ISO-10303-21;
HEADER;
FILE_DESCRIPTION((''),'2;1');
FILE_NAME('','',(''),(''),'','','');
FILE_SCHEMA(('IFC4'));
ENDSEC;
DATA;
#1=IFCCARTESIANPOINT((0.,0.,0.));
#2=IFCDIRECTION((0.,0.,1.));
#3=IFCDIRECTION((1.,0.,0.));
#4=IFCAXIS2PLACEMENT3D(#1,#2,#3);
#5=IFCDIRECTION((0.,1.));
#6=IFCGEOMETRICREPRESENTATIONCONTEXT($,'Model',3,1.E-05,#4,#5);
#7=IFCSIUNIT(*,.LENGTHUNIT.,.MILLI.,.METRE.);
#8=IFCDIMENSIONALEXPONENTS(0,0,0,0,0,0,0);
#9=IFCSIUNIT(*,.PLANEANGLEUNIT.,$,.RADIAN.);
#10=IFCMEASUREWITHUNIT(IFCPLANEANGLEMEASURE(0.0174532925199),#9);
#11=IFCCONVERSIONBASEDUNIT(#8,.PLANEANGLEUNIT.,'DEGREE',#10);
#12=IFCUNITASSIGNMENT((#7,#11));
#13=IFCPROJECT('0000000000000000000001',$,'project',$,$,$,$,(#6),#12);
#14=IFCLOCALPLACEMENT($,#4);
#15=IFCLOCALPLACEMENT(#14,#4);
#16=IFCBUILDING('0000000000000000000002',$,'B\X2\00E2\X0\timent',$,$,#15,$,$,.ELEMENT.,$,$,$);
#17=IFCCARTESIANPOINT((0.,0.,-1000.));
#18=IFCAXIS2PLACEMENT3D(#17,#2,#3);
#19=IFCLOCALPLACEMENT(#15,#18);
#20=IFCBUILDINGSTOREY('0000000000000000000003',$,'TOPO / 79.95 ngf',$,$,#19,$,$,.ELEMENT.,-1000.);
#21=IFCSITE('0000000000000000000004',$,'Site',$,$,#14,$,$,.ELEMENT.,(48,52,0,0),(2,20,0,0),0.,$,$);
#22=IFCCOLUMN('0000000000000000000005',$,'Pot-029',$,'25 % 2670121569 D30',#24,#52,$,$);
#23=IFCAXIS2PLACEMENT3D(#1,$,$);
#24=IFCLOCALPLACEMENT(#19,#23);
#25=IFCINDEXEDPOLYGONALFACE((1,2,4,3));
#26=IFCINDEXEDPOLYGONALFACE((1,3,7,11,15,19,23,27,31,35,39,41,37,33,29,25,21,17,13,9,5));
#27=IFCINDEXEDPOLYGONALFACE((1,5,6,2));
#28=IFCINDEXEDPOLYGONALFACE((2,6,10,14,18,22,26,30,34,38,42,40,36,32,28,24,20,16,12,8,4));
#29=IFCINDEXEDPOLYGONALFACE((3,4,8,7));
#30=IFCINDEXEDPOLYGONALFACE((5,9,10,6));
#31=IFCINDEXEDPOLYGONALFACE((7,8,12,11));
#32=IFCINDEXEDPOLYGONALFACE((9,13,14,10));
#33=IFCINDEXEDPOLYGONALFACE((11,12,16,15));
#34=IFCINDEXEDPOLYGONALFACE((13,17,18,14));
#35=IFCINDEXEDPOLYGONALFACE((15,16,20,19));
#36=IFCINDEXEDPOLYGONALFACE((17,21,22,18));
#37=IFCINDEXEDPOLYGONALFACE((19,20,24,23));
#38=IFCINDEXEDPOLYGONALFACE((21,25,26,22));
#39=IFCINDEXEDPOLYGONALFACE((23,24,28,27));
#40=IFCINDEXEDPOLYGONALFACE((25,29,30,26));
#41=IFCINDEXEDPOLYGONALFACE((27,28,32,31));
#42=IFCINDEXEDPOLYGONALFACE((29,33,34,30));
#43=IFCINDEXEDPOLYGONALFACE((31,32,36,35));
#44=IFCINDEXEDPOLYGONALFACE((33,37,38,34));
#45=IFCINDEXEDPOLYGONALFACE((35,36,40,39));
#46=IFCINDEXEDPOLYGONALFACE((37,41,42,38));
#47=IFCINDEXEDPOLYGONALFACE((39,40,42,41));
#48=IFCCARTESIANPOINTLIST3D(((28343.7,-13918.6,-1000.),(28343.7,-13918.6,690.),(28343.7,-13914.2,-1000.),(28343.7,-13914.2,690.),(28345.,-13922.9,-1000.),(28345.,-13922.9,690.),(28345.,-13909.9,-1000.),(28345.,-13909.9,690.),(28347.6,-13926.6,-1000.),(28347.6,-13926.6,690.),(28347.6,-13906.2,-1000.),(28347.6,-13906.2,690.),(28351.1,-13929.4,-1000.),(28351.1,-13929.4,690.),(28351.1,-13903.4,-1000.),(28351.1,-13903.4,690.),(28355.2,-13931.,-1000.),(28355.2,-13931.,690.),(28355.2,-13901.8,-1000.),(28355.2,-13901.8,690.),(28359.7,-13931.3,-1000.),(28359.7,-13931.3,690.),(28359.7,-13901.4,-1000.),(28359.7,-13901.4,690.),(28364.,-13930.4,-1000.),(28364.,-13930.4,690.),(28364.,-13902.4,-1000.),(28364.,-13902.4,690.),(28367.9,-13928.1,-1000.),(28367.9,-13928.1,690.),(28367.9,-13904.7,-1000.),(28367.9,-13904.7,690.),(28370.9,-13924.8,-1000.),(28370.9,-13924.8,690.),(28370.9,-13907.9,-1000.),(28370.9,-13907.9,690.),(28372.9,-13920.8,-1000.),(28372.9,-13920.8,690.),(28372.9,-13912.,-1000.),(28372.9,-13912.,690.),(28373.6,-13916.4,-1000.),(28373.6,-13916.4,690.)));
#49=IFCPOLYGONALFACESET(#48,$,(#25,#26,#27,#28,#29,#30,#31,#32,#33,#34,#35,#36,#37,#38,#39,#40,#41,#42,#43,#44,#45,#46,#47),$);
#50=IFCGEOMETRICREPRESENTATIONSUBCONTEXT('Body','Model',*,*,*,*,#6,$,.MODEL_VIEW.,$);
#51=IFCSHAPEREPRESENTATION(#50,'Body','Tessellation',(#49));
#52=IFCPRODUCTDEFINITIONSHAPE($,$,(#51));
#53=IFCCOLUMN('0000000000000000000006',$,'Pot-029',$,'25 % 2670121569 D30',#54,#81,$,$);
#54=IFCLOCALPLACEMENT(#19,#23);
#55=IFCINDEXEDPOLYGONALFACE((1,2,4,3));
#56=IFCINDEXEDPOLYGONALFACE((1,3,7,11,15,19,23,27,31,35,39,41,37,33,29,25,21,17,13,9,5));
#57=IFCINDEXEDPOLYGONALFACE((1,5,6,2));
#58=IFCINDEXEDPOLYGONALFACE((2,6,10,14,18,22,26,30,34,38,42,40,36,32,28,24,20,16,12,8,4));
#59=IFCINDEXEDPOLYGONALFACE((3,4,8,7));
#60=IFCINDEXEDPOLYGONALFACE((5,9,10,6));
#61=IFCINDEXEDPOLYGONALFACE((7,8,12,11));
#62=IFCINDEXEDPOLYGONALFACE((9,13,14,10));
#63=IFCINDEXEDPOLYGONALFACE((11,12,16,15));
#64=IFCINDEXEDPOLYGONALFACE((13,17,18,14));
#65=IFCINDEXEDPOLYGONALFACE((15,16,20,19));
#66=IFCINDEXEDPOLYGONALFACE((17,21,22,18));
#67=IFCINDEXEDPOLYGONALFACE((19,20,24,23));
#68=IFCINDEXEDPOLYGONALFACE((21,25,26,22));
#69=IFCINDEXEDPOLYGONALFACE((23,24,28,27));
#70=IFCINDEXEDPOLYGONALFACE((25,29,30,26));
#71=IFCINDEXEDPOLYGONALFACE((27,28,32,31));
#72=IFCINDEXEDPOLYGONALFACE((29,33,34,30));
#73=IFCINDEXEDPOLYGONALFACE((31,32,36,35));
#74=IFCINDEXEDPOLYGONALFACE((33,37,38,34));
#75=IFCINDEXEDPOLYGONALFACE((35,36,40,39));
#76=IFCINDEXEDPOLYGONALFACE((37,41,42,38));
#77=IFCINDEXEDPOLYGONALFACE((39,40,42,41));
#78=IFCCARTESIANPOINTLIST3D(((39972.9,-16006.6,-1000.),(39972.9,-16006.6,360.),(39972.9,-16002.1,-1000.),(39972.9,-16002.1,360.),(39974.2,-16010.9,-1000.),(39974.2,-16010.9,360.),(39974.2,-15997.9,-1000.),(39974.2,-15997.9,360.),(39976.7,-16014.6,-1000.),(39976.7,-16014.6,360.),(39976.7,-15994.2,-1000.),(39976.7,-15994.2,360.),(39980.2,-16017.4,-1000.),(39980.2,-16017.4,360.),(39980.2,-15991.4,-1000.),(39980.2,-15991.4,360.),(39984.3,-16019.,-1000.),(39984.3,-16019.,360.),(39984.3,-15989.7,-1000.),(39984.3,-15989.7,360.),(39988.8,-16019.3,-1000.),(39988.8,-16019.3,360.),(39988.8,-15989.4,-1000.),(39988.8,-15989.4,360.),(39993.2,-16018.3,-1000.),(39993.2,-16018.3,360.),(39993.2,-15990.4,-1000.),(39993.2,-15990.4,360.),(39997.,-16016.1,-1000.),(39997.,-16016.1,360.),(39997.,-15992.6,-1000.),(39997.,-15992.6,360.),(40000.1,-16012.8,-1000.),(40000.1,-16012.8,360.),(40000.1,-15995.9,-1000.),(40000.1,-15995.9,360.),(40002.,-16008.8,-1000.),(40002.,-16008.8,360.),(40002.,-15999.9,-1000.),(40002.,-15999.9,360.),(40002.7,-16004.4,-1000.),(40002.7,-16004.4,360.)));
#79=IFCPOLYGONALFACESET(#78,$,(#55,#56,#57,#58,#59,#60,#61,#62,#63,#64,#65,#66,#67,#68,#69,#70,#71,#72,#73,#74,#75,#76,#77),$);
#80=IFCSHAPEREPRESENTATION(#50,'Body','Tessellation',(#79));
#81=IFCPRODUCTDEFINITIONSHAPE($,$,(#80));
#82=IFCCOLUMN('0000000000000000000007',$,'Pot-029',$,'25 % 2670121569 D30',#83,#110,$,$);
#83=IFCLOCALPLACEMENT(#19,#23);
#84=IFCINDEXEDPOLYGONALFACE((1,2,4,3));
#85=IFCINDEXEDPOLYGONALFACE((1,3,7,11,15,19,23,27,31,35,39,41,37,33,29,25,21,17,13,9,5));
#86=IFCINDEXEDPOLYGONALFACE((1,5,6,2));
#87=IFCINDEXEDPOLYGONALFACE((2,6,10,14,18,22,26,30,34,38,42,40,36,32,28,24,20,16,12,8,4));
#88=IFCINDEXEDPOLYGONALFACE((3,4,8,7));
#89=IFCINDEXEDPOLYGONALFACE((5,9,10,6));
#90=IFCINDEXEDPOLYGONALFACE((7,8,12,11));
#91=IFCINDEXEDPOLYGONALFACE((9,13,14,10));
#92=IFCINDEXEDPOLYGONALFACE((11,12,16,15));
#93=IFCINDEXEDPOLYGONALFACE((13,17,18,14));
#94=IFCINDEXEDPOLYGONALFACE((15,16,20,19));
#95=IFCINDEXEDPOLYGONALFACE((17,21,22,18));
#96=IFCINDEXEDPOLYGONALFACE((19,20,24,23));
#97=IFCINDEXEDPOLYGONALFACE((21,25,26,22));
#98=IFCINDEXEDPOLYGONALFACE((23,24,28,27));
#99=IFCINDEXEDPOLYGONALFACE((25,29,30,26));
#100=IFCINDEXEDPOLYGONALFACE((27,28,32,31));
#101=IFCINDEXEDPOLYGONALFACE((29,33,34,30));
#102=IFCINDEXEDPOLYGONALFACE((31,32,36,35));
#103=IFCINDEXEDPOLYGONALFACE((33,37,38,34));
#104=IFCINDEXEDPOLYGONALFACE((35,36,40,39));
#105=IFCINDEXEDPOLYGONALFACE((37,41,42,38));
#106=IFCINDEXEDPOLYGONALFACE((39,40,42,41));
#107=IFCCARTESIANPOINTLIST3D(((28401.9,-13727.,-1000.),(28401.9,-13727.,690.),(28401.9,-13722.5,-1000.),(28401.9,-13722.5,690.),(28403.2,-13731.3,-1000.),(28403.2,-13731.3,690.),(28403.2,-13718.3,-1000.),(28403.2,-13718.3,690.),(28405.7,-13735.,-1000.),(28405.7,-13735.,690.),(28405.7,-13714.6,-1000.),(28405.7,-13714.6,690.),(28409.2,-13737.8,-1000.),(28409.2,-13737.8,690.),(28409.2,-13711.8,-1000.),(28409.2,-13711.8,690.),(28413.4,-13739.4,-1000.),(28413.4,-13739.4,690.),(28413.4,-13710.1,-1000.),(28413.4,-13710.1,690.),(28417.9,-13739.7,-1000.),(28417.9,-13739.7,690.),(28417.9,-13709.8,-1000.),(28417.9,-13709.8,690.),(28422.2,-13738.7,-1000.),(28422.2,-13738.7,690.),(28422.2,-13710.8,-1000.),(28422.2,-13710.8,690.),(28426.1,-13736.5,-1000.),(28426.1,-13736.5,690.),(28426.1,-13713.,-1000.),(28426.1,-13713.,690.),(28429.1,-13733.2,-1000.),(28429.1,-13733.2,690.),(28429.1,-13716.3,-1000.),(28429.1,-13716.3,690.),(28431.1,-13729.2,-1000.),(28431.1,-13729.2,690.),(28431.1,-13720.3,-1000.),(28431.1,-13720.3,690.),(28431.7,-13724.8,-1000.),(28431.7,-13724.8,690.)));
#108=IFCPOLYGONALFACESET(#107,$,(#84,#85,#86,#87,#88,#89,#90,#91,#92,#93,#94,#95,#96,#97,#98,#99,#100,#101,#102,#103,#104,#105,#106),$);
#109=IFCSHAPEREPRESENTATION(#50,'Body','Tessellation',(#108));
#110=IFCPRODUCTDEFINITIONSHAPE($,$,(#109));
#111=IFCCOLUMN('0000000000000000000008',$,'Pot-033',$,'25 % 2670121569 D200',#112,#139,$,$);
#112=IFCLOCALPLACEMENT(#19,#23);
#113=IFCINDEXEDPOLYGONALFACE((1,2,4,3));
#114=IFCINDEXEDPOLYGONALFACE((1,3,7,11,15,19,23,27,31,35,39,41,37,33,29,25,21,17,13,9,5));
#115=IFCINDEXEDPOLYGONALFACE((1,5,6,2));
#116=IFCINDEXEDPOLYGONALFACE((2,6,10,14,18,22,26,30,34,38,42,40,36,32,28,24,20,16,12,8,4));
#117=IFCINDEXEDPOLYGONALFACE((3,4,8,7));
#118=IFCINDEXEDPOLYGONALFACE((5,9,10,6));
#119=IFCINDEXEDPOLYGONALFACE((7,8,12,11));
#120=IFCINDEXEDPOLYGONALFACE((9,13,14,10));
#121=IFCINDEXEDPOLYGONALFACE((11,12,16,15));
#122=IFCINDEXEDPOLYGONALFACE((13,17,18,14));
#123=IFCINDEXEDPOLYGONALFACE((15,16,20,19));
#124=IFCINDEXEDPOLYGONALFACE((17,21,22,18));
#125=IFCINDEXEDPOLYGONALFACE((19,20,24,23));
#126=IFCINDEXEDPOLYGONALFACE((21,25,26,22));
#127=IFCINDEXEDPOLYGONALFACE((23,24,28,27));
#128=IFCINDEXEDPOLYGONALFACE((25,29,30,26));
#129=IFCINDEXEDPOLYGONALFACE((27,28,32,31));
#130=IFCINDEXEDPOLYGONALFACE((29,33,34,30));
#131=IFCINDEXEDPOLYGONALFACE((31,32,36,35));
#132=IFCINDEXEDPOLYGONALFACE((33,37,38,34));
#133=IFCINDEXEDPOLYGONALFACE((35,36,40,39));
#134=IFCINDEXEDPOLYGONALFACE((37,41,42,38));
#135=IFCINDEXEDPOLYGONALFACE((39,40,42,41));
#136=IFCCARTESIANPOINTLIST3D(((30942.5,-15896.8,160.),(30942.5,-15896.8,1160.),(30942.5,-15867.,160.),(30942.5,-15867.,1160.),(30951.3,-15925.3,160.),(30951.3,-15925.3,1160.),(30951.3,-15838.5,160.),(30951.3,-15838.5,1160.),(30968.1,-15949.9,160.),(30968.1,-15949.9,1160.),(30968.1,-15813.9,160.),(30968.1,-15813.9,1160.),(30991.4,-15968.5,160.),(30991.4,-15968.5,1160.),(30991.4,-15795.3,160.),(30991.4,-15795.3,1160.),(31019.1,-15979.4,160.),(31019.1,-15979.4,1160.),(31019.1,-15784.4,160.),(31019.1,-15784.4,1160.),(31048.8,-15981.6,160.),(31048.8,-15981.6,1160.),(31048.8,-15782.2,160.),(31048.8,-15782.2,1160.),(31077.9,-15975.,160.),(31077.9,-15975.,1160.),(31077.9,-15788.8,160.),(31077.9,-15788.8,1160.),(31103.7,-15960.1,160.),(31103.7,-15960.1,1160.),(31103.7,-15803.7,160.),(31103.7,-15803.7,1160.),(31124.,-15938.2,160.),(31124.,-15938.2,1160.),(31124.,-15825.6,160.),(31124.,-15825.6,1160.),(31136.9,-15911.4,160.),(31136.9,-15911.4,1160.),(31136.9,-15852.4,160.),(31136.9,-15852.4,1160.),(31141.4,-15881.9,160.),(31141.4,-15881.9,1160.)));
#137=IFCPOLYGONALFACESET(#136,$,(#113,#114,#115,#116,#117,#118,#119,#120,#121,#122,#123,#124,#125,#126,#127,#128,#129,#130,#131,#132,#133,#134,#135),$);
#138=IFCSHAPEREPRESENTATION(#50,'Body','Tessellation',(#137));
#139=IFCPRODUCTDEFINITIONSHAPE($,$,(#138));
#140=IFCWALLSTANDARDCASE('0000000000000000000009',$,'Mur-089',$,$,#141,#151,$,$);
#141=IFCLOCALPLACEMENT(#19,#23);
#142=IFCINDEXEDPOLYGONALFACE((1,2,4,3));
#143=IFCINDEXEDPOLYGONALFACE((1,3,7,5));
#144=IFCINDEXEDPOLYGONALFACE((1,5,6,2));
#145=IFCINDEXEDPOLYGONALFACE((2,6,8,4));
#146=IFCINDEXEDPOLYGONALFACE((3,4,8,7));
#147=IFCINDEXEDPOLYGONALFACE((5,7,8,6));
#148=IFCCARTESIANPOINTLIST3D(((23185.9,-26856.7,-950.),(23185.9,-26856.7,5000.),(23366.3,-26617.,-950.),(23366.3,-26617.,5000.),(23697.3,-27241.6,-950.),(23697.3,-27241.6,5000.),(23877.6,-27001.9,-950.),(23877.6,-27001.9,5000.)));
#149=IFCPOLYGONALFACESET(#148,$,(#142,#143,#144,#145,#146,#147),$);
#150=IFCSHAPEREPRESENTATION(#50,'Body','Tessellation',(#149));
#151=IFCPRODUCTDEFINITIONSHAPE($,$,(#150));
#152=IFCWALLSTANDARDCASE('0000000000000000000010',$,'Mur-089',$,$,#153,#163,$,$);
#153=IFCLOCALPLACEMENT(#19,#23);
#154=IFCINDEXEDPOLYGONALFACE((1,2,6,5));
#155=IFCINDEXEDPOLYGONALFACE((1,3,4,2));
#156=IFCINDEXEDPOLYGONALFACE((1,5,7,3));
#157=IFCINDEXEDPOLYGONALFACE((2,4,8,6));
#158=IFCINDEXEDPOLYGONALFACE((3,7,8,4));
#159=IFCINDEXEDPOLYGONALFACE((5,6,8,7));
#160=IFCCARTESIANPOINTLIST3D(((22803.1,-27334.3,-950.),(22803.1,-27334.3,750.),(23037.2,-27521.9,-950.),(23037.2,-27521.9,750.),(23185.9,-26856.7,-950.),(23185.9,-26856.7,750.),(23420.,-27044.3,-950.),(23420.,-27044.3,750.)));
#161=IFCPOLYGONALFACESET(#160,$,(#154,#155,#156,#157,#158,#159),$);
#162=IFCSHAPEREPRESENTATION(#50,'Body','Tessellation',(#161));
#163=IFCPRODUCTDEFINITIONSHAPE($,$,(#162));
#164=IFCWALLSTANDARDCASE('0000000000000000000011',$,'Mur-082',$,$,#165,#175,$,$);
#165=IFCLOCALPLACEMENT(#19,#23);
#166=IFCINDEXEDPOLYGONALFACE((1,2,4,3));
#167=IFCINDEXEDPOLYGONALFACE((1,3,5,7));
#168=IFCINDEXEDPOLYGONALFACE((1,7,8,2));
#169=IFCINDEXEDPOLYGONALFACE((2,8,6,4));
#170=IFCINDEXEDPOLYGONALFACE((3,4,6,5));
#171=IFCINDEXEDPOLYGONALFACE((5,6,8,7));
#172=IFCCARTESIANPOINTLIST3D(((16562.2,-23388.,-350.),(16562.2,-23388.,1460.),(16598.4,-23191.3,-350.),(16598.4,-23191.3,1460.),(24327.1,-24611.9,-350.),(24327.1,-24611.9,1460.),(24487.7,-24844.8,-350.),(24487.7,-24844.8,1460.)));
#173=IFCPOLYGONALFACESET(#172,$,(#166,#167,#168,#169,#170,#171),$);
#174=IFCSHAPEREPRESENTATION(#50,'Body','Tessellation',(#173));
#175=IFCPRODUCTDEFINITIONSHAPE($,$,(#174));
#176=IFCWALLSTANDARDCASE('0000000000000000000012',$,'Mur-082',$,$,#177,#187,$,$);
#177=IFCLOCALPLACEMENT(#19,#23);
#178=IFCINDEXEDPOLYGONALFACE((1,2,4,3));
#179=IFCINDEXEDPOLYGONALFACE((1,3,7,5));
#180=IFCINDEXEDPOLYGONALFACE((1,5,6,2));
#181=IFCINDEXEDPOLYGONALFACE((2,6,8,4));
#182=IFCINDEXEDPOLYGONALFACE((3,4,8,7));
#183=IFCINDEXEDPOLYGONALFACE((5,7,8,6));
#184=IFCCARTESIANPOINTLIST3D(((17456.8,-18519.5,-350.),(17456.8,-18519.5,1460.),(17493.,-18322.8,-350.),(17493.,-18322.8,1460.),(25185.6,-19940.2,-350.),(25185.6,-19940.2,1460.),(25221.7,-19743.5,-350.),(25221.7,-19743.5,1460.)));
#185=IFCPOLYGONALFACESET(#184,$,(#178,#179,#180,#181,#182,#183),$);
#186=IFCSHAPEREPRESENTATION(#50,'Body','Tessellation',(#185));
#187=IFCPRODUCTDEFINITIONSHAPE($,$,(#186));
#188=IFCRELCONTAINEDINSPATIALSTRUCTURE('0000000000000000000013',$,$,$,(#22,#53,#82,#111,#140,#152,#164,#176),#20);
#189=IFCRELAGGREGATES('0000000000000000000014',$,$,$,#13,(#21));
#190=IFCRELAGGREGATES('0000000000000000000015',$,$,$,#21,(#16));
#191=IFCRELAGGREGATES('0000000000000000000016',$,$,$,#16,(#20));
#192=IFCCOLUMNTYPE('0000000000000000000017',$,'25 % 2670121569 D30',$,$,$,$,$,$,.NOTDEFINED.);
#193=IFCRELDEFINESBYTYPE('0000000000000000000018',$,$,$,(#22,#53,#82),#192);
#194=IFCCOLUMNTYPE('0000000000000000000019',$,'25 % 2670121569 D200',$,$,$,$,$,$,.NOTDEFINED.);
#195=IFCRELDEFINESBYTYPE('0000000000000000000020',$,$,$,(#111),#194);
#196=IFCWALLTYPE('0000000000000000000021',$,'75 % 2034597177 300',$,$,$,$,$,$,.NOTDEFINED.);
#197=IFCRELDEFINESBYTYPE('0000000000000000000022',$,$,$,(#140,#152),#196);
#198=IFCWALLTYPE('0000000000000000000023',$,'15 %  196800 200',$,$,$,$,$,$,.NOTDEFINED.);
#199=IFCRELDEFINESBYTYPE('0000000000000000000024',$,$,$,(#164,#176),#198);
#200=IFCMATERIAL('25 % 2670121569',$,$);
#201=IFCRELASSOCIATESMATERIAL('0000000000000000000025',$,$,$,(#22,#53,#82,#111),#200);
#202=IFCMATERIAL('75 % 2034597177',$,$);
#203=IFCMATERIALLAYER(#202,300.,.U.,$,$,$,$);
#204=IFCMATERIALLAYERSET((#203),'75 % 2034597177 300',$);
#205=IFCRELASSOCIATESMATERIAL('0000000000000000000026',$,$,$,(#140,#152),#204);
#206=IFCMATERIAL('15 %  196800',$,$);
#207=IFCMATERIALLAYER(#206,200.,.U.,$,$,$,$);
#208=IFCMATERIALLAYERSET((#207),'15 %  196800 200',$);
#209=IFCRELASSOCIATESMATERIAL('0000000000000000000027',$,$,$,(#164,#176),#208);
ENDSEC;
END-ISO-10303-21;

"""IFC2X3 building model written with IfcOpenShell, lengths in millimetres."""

from ifc_helpers import new_model, entity, si_unit, converted_unit, direction, frame, origin_with_axes, origin_2d_with_axis, place, context, subcontext, project, spatial, polyline, circle, outline, extrude, material, layer, layer_set, layer_usage, type_object, element, save


model = new_model("IFC2X3")

# Units and contexts
model_context = context("Model", 3, precision=1e-05, world=origin_with_axes(), true_north=direction((0.0, 1.0)))
body_context = subcontext(model_context, "Body", "Model", "MODEL_VIEW")
ifc_project = project(units=[si_unit("LENGTHUNIT", "METRE", prefix="MILLI"), converted_unit("PLANEANGLEUNIT", "DEGREE", entity("IfcPlaneAngleMeasure", 0.0174532925199), si_unit("PLANEANGLEUNIT", "RADIAN"), dimensions=[0, 0, 0, 0, 0, 0, 0])], contexts=[model_context])

# Site, building, storey
site_placement = place(None, origin_with_axes())
site = spatial("IfcSite", under=ifc_project, at=site_placement, Name="Site", CompositionType="ELEMENT", RefLatitude=(48, 52, 0, 0), RefLongitude=(2, 20, 0, 0), RefElevation=0.0)
building_placement = place(site_placement, origin_with_axes())
building = spatial("IfcBuilding", under=site, at=building_placement, Name="Bâtiment", CompositionType="ELEMENT")
storey_placement = place(building_placement, frame((0.0, 0.0, -1000.0), z_axis=(0.0, 0.0, 1.0), x_axis=(1.0, 0.0, 0.0)))
storey = spatial("IfcBuildingStorey", under=building, at=storey_placement, Name="TOPO / 79.95 ngf", CompositionType="ELEMENT", Elevation=-1000.0)

# Columns
ifc_material_1 = material(Name="25 % 2670121569")
column_type_1 = type_object("IfcColumnType", Name="25 % 2670121569 D30", PredefinedType="NOTDEFINED")
column_1_placement = place(storey_placement, frame((28358.6, -13916.4, -1000.0), z_axis=(0.0, 0.0, 1.0), x_axis=(1.0, 0.0, 0.0)))
element("IfcColumn", 1, at=column_1_placement, inside=storey, type_object=column_type_1, material=ifc_material_1, Name="Pot-029", ObjectType="25 % 2670121569 D30", context=body_context, shape_type="SweptSolid", body=[
    extrude(circle(Radius=15.0, at=origin_2d_with_axis()), origin_with_axes(), (0.0, 0.0, 1.0), 1690.0),
])
column_2_placement = place(storey_placement, frame((39987.7, -16004.4, -1000.0), z_axis=(0.0, 0.0, 1.0), x_axis=(1.0, 0.0, 0.0)))
element("IfcColumn", 2, at=column_2_placement, inside=storey, type_object=column_type_1, material=ifc_material_1, Name="Pot-029", ObjectType="25 % 2670121569 D30", context=body_context, shape_type="SweptSolid", body=[
    extrude(circle(Radius=15.0, at=origin_2d_with_axis()), origin_with_axes(), (0.0, 0.0, 1.0), 1360.0),
])
column_3_placement = place(storey_placement, frame((28416.7, -13724.8, -1000.0), z_axis=(0.0, 0.0, 1.0), x_axis=(1.0, 0.0, 0.0)))
element("IfcColumn", 3, at=column_3_placement, inside=storey, type_object=column_type_1, material=ifc_material_1, Name="Pot-029", ObjectType="25 % 2670121569 D30", context=body_context, shape_type="SweptSolid", body=[
    extrude(circle(Radius=15.0, at=origin_2d_with_axis()), origin_with_axes(), (0.0, 0.0, 1.0), 1690.0),
])
column_type_2 = type_object("IfcColumnType", Name="25 % 2670121569 D200", PredefinedType="NOTDEFINED")
column_4_placement = place(storey_placement, frame((31041.4, -15881.9, 160.0), z_axis=(0.0, 0.0, 1.0), x_axis=(1.0, 0.0, 0.0)))
element("IfcColumn", 4, at=column_4_placement, inside=storey, type_object=column_type_2, material=ifc_material_1, Name="Pot-033", ObjectType="25 % 2670121569 D200", context=body_context, shape_type="SweptSolid", body=[
    extrude(circle(Radius=100.0, at=origin_2d_with_axis()), origin_with_axes(), (0.0, 0.0, 1.0), 1000.0),
])

# Walls
ifc_material_2 = material(Name="75 % 2034597177")
ifc_layer_1 = layer(ifc_material_2, 300.0, ventilated="UNKNOWN")
ifc_layer_set_1 = layer_set([ifc_layer_1], Name="75 % 2034597177 300")
ifc_layer_usage_1 = layer_usage(ifc_layer_set_1, "AXIS2", "POSITIVE", -300.0)
wall_type_1 = type_object("IfcWallType", Name="75 % 2034597177 300", PredefinedType="NOTDEFINED")
wall_1_placement = place(storey_placement, frame((23366.3, -26617.0, -950.0), z_axis=(0.0, 0.0, 1.0), x_axis=(0.799009, -0.60132, 0.0)))
element("IfcWallStandardCase", 5, at=wall_1_placement, inside=storey, type_object=wall_type_1, material=ifc_layer_usage_1, Name="Mur-089", context=body_context, shape_type="SweptSolid", body=[
    extrude(outline(polyline([(0.0, -300.0), (640.0, -300.0), (640.0, 0.0), (0.0, 0.0), (0.0, -300.0)])), origin_with_axes(), (0.0, 0.0, 1.0), 5950.0),
])
ifc_layer_usage_2 = layer_usage(ifc_layer_set_1, "AXIS2", "NEGATIVE", 300.0)
wall_2_placement = place(storey_placement, frame((23185.9, -26856.7, -950.0), z_axis=(0.0, 0.0, 1.0), x_axis=(-0.625413, -0.780294, 0.0)))
element("IfcWallStandardCase", 6, at=wall_2_placement, inside=storey, type_object=wall_type_1, material=ifc_layer_usage_2, Name="Mur-089", context=body_context, shape_type="SweptSolid", body=[
    extrude(outline(polyline([(0.0, 0.0), (612.1, 0.0), (612.1, 300.0), (0.0, 300.0), (0.0, 0.0)])), origin_with_axes(), (0.0, 0.0, 1.0), 1700.0),
])
ifc_material_3 = material(Name="15 %  196800")
ifc_layer_2 = layer(ifc_material_3, 200.0, ventilated="UNKNOWN")
ifc_layer_set_2 = layer_set([ifc_layer_2], Name="15 %  196800 200")
ifc_layer_usage_3 = layer_usage(ifc_layer_set_2, "AXIS2", "NEGATIVE", 100.0)
wall_type_2 = type_object("IfcWallType", Name="15 %  196800 200", PredefinedType="NOTDEFINED")
wall_3_placement = place(storey_placement, frame((24505.8, -24746.5, -350.0), z_axis=(0.0, 0.0, 1.0), x_axis=(-0.983524, 0.18078, 0.0)))
element("IfcWallStandardCase", 7, at=wall_3_placement, inside=storey, type_object=wall_type_2, material=ifc_layer_usage_3, Name="Mur-082", context=body_context, shape_type="SweptSolid", body=[
    extrude(outline(polyline([(200.0, -100.0), (8058.2, -100.0), (8058.2, 100.0), (0.0, 100.0), (200.0, -100.0)])), origin_with_axes(), (0.0, 0.0, 1.0), 1810.0),
])
ifc_layer_usage_4 = layer_usage(ifc_layer_set_2, "AXIS2", "NEGATIVE", 100.0)
wall_4_placement = place(storey_placement, frame((25400.4, -19878.0, -350.0), z_axis=(0.0, 0.0, 1.0), x_axis=(-0.983524, 0.18078, 0.0)))
element("IfcWallStandardCase", 8, at=wall_4_placement, inside=storey, type_object=wall_type_2, material=ifc_layer_usage_4, Name="Mur-082", context=body_context, shape_type="SweptSolid", body=[
    extrude(outline(polyline([(200.0, -100.0), (8058.2, -100.0), (8058.2, 100.0), (200.0, 100.0), (200.0, -100.0)])), origin_with_axes(), (0.0, 0.0, 1.0), 1810.0),
])

save(model, "model.ifc")
